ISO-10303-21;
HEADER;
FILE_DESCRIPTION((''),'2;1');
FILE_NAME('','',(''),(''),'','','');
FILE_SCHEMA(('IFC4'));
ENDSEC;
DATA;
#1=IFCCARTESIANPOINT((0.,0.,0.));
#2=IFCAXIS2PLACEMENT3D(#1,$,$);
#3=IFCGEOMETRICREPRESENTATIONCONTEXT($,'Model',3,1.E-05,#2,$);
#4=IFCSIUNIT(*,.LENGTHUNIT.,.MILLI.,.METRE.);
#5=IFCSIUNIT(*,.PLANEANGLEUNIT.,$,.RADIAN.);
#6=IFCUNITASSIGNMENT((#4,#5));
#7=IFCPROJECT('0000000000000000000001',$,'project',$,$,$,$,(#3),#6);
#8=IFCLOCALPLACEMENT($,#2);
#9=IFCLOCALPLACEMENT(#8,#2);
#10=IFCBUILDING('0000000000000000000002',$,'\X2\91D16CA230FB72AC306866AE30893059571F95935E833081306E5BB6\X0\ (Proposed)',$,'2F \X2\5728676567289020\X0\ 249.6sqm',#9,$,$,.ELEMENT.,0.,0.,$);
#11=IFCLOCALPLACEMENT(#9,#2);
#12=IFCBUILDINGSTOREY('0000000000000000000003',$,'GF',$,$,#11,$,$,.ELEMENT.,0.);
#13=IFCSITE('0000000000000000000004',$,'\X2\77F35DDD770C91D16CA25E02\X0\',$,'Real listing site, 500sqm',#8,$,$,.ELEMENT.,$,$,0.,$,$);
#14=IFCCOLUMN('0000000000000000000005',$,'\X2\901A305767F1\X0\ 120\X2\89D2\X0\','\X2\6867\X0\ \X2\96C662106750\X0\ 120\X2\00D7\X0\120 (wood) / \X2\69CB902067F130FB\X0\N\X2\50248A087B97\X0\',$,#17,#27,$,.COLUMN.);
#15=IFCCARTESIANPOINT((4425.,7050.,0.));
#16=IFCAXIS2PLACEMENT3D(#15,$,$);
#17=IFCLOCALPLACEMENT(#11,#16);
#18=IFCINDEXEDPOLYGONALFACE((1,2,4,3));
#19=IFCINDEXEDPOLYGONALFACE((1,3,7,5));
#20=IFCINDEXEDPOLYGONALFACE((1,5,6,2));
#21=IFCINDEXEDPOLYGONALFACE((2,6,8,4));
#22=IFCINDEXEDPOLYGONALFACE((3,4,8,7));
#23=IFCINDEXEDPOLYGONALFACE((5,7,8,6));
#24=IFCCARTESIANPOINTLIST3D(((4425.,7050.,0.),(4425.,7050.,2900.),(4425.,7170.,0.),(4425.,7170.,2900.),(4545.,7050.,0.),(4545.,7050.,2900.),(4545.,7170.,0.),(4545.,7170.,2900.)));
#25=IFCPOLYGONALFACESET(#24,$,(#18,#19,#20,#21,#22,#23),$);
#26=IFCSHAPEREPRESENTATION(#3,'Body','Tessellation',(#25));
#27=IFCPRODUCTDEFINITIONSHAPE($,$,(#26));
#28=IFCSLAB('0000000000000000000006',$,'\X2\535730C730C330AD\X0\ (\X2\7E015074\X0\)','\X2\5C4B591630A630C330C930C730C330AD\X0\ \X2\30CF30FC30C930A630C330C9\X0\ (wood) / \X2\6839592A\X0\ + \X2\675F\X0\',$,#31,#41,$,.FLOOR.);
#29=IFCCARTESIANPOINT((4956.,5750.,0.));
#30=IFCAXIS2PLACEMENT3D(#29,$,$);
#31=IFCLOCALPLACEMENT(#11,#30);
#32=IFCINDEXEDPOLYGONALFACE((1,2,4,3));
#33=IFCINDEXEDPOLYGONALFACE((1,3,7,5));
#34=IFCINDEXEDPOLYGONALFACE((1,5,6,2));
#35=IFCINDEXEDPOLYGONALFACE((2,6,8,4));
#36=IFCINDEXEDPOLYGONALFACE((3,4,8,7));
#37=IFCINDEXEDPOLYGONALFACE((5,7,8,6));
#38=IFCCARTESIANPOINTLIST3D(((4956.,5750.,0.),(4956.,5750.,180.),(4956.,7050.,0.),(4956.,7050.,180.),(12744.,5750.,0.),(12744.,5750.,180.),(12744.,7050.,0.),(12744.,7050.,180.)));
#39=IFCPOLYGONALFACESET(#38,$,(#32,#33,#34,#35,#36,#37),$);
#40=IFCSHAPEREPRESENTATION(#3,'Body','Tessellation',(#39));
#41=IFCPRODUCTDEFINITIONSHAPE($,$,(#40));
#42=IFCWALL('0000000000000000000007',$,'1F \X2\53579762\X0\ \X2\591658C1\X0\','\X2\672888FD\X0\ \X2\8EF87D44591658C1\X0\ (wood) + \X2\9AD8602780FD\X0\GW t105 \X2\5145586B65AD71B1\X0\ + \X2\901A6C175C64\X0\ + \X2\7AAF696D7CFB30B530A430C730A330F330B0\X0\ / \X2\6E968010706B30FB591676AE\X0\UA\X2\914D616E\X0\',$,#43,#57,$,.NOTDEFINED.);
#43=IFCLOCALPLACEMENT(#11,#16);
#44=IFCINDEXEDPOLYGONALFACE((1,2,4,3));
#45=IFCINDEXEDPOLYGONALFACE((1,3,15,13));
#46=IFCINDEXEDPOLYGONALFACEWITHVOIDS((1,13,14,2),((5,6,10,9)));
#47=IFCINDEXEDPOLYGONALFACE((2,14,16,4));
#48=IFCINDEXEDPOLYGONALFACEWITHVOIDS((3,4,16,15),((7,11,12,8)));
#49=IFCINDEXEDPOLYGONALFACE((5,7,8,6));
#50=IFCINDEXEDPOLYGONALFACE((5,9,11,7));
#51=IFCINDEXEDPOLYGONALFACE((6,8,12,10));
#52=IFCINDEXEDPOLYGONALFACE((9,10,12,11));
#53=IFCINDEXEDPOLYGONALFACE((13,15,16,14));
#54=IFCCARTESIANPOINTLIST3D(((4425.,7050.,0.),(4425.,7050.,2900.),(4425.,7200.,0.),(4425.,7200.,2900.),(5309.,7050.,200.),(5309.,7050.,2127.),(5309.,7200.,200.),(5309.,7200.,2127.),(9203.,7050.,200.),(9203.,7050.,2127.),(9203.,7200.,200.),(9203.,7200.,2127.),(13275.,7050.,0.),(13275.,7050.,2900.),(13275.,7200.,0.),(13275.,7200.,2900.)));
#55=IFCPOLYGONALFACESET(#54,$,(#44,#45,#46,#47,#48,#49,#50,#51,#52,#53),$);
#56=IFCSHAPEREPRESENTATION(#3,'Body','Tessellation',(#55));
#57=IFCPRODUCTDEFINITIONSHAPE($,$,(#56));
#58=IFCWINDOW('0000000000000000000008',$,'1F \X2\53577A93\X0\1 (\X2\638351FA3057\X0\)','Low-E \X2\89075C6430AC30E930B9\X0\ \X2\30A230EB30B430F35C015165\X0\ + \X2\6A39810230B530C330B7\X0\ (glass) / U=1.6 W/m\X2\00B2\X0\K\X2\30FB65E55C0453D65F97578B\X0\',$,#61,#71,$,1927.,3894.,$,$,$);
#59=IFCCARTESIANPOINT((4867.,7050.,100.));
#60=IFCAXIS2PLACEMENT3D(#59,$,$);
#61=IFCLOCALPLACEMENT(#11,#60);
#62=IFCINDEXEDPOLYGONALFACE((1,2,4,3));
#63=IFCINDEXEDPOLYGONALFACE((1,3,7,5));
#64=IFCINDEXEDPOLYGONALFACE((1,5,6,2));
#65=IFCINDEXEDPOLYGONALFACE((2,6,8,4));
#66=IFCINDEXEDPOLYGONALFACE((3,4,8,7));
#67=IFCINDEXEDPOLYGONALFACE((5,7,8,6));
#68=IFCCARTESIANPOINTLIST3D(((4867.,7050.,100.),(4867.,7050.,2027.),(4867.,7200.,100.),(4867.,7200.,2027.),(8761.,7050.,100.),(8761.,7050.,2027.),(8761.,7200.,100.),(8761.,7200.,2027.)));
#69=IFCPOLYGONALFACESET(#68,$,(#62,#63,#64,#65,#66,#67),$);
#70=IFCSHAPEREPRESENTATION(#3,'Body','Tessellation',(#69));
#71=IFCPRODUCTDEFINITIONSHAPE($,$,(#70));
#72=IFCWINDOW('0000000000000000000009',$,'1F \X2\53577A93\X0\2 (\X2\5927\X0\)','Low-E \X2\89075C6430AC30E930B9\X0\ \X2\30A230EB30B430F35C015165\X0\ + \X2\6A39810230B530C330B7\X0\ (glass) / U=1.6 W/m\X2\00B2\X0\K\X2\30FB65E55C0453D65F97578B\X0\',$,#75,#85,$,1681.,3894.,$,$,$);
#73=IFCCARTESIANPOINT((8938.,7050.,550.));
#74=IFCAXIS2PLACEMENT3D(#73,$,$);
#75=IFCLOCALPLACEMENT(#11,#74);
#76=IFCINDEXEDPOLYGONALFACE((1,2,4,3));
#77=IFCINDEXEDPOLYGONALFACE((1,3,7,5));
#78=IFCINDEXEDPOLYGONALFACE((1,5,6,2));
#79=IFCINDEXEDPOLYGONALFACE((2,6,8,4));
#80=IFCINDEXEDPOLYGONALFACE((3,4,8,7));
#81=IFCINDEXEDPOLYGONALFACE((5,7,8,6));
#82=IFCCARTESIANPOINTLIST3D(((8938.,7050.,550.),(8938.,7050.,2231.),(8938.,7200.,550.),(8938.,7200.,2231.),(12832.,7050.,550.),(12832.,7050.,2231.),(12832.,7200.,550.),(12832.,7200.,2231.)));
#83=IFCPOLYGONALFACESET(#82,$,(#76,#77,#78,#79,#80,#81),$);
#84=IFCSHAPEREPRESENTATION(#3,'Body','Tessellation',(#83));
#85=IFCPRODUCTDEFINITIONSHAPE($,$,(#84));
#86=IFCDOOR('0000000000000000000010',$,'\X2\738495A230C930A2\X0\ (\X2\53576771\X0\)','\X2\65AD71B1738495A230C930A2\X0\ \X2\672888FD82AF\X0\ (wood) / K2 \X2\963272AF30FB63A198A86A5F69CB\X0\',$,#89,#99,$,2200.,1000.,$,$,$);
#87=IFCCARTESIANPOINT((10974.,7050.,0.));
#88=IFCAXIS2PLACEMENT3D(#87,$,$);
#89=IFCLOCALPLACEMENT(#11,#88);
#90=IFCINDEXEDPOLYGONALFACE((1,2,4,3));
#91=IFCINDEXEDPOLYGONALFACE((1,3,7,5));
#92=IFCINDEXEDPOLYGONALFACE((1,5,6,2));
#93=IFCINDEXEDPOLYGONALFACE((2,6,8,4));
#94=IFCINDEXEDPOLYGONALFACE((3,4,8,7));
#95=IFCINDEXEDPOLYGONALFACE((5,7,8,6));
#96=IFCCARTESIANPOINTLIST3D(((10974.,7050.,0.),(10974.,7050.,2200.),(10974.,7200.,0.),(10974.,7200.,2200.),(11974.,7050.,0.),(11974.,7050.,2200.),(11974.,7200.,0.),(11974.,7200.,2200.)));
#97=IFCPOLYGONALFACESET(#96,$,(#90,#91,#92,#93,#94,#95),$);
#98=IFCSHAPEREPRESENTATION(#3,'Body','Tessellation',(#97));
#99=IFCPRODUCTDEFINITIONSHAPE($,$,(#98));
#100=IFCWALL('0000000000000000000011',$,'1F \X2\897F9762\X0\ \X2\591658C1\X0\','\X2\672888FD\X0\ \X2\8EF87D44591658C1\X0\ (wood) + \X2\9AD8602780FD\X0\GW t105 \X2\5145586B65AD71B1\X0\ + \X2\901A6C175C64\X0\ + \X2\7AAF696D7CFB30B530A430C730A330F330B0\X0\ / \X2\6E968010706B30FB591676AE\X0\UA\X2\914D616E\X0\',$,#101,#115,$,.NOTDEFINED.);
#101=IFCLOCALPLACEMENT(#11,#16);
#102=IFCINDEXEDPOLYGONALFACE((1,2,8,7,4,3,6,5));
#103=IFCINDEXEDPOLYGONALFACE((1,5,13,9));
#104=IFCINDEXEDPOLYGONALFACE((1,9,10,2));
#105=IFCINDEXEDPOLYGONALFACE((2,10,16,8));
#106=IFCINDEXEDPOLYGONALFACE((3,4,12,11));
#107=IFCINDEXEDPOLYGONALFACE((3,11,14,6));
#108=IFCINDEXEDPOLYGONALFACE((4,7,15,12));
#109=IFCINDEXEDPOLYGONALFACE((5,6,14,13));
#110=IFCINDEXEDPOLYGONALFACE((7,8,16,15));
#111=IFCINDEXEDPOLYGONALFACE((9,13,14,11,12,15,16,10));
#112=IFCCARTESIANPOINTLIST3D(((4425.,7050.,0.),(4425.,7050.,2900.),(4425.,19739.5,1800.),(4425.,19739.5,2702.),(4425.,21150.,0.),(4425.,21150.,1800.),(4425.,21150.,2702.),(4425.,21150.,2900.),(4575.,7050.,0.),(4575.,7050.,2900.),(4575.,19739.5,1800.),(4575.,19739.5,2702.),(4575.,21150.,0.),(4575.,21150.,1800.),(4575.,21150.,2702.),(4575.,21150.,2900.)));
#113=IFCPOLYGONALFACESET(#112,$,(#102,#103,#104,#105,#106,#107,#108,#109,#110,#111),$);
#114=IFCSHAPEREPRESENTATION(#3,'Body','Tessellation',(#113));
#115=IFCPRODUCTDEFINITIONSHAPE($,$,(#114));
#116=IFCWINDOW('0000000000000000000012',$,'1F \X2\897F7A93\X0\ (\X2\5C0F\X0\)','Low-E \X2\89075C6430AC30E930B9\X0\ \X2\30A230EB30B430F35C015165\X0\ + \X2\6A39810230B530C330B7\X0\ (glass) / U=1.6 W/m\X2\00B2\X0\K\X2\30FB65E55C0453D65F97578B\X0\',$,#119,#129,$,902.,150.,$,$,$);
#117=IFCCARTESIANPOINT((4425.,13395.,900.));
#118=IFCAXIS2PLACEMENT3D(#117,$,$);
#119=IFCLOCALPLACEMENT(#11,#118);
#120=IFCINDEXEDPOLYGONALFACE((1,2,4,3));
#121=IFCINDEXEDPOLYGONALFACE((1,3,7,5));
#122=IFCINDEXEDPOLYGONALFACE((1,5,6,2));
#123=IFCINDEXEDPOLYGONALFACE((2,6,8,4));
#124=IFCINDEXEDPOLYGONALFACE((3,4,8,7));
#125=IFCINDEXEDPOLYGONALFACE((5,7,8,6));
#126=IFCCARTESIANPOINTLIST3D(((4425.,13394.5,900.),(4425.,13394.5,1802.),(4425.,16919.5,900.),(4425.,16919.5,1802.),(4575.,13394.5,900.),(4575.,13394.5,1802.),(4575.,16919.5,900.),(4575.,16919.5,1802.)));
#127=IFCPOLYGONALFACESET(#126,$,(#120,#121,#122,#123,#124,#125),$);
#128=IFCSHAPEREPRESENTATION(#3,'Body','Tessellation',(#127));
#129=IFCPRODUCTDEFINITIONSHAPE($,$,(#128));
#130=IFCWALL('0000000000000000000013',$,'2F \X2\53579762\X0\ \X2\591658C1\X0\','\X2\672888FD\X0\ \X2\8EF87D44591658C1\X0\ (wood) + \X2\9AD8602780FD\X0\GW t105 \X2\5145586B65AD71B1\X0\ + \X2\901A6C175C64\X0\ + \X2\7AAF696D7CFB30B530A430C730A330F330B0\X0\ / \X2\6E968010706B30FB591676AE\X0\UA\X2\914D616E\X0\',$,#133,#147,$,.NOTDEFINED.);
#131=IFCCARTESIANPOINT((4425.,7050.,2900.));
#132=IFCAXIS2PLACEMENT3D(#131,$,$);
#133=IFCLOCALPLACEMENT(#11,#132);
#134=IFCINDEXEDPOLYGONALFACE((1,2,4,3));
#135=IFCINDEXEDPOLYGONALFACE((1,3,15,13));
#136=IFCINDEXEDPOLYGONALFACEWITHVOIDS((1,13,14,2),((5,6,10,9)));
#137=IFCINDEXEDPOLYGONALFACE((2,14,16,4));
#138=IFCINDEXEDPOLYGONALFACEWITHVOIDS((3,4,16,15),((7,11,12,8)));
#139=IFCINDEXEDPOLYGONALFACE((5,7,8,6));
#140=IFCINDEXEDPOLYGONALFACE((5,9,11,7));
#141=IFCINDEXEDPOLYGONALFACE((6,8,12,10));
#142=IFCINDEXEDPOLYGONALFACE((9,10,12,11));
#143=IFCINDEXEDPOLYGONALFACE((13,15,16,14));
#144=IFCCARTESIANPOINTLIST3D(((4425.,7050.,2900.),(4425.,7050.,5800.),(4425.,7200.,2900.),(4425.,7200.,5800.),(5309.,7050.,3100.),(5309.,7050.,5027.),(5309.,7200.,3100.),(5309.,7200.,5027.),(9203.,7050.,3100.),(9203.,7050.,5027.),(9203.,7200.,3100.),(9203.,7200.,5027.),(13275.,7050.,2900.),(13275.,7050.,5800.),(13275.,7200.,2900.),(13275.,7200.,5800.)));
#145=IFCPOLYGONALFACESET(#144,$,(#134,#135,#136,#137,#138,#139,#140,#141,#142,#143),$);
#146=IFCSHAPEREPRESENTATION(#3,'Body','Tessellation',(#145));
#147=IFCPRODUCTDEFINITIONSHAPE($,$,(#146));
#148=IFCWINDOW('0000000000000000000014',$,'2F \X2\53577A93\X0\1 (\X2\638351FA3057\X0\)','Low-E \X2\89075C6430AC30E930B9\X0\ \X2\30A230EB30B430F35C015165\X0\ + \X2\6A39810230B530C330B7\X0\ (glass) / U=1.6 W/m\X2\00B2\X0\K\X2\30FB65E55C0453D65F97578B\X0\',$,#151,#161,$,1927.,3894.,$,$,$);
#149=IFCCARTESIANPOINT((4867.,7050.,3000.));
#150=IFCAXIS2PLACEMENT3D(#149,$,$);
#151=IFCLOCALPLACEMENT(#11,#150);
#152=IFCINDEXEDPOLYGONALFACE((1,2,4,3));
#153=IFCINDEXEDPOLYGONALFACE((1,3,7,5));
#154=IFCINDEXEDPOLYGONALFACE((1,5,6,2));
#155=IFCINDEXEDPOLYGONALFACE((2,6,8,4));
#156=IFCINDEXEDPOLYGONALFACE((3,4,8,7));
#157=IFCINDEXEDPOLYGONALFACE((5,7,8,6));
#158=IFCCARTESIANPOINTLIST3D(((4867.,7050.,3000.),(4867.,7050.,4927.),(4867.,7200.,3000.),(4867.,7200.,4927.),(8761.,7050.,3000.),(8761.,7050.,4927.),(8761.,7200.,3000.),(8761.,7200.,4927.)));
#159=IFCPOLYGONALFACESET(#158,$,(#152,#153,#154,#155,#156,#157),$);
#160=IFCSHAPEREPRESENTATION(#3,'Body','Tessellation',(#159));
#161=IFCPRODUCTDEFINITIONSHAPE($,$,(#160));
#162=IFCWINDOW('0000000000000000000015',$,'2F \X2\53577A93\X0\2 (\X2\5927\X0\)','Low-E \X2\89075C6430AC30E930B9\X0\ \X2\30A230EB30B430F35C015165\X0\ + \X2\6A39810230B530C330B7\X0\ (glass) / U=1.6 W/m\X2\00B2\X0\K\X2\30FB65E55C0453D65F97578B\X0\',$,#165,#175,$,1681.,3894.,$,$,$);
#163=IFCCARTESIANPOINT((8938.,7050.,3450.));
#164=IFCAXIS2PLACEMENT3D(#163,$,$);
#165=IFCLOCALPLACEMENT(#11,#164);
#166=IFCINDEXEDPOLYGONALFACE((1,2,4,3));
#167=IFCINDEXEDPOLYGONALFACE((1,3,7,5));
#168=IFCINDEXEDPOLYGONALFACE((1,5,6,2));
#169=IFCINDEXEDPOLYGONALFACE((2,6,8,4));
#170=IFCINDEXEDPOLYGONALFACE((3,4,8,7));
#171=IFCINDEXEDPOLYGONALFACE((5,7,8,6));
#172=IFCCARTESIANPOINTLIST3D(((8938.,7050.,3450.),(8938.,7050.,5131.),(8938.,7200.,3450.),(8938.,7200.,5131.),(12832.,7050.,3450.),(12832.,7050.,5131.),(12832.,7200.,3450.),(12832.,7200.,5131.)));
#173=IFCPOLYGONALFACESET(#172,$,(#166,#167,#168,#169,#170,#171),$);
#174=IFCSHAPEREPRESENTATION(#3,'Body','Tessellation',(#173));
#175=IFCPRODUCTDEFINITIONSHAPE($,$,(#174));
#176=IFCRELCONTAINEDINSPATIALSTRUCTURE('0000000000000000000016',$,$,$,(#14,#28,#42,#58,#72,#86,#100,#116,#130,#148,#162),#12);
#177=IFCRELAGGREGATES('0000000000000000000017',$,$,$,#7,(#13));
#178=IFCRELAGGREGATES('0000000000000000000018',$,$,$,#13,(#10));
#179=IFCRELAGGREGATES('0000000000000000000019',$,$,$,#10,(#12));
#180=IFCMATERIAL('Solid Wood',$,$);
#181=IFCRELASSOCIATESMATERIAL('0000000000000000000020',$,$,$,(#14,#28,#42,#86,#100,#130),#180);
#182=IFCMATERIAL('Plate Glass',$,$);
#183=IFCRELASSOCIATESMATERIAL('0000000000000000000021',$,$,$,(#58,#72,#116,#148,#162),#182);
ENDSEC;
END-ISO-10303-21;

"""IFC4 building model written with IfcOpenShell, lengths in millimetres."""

from ifc_helpers import new_model, si_unit, frame, frame_2d, origin, place, context, project, spatial, rectangle, extrude, material, element, fill, save


model = new_model("IFC4")

# Units and contexts
model_context = context("Model", 3, precision=1e-05, world=origin())
ifc_project = project(units=[si_unit("LENGTHUNIT", "METRE", prefix="MILLI"), si_unit("PLANEANGLEUNIT", "RADIAN")], contexts=[model_context])

# Site, building, storey
site_placement = place(None, origin())
site = spatial("IfcSite", under=ifc_project, at=site_placement, Name="石川県金沢市", ObjectType="Real listing site, 500sqm", CompositionType="ELEMENT", RefElevation=0.0)
building_placement = place(site_placement, origin())
building = spatial("IfcBuilding", under=site, at=building_placement, Name="金沢・犬と暮らす土間広めの家 (Proposed)", ObjectType="2F 在来木造 249.6sqm", CompositionType="ELEMENT", ElevationOfRefHeight=0.0, ElevationOfTerrain=0.0)
storey_placement = place(building_placement, origin())
storey = spatial("IfcBuildingStorey", under=building, at=storey_placement, Name="GF", CompositionType="ELEMENT", Elevation=0.0)

# Column
ifc_material_1 = material(Name="Solid Wood")
column_placement = place(storey_placement, frame((4425.0, 7050.0, 0.0)))
element("IfcColumn", 1, at=column_placement, inside=storey, material=ifc_material_1, Name="通し柱 120角", Description="桧 集成材 120×120 (wood) / 構造柱・N値計算", PredefinedType="COLUMN", context=model_context, shape_type="SweptSolid", body=[
    extrude(rectangle(XDim=120.0, YDim=120.0, at=frame_2d((60.0, 60.0))), frame((4425.0, 7050.0, 0.0)), (0.0, 0.0, 1.0), 2900.0),
])

# Slab
slab_1_placement = place(storey_placement, frame((4956.0, 5750.0, 0.0)))
element("IfcSlab", 2, at=slab_1_placement, inside=storey, material=ifc_material_1, Name="南デッキ (縁側)", Description="屋外ウッドデッキ ハードウッド (wood) / 根太 + 束", PredefinedType="FLOOR", context=model_context, shape_type="SweptSolid", body=[
    extrude(rectangle(XDim=7788.0, YDim=1300.0, at=frame_2d((3894.0, 650.0))), frame((4956.0, 5750.0, 0.0)), (0.0, 0.0, 1.0), 180.0),
])

# Wall, openings, windows, door
wall_1_placement = place(storey_placement, frame((4425.0, 7050.0, 0.0)))
wall_1 = element("IfcWall", 3, at=wall_1_placement, inside=storey, material=ifc_material_1, Name="1F 南面 外壁", Description="木製 軸組外壁 (wood) + 高性能GW t105 充填断熱 + 通気層 + 窯業系サイディング / 準耐火・外皮UA配慮", PredefinedType="NOTDEFINED", context=model_context, shape_type="SweptSolid", body=[
    extrude(rectangle(XDim=8850.0, YDim=150.0, at=frame_2d((4425.0, 75.0))), frame((4425.0, 7050.0, 0.0)), (0.0, 0.0, 1.0), 2900.0),
])
opening_1_placement = place(storey_placement, frame((4867.0, 7050.0, 100.0)))
opening_1 = element("IfcOpeningElement", 4, at=opening_1_placement, cuts=wall_1, PredefinedType="NOTDEFINED", context=model_context, shape_type="SweptSolid", body=[
    extrude(rectangle(XDim=3894.0, YDim=150.0, at=frame_2d((1947.0, 75.0))), frame((4867.0, 7050.0, 100.0)), (0.0, 0.0, 1.0), 1927.0),
])
opening_2_placement = place(storey_placement, frame((8938.0, 7050.0, 550.0)))
opening_2 = element("IfcOpeningElement", 5, at=opening_2_placement, cuts=wall_1, PredefinedType="NOTDEFINED", context=model_context, shape_type="SweptSolid", body=[
    extrude(rectangle(XDim=3894.0, YDim=150.0, at=frame_2d((1947.0, 75.0))), frame((8938.0, 7050.0, 550.0)), (0.0, 0.0, 1.0), 1681.0),
])
opening_3_placement = place(storey_placement, frame((10974.0, 7050.0, 0.0)))
opening_3 = element("IfcOpeningElement", 6, at=opening_3_placement, cuts=wall_1, PredefinedType="NOTDEFINED", context=model_context, shape_type="SweptSolid", body=[
    extrude(rectangle(XDim=1000.0, YDim=150.0, at=frame_2d((500.0, 75.0))), frame((10974.0, 7050.0, 0.0)), (0.0, 0.0, 1.0), 2200.0),
])
ifc_material_2 = material(Name="Plate Glass")
window_1_placement = place(storey_placement, frame((4867.0, 7050.0, 100.0)))
window_1 = element("IfcWindow", 7, at=window_1_placement, inside=storey, material=ifc_material_2, Name="1F 南窓1 (掃出し)", Description="Low-E 複層ガラス アルゴン封入 + 樹脂サッシ (glass) / U=1.6 W/m²K・日射取得型", OverallHeight=1927.0, OverallWidth=3894.0, context=model_context, shape_type="SweptSolid", body=[
    extrude(rectangle(XDim=3894.0, YDim=150.0, at=frame_2d((1947.0, 75.0))), frame((4867.0, 7050.0, 100.0)), (0.0, 0.0, 1.0), 1927.0),
])
fill(opening_1, window_1)
window_2_placement = place(storey_placement, frame((8938.0, 7050.0, 550.0)))
window_2 = element("IfcWindow", 8, at=window_2_placement, inside=storey, material=ifc_material_2, Name="1F 南窓2 (大)", Description="Low-E 複層ガラス アルゴン封入 + 樹脂サッシ (glass) / U=1.6 W/m²K・日射取得型", OverallHeight=1681.0, OverallWidth=3894.0, context=model_context, shape_type="SweptSolid", body=[
    extrude(rectangle(XDim=3894.0, YDim=150.0, at=frame_2d((1947.0, 75.0))), frame((8938.0, 7050.0, 550.0)), (0.0, 0.0, 1.0), 1681.0),
])
fill(opening_2, window_2)
door_placement = place(storey_placement, frame((10974.0, 7050.0, 0.0)))
door = element("IfcDoor", 9, at=door_placement, inside=storey, material=ifc_material_1, Name="玄関ドア (南東)", Description="断熱玄関ドア 木製芯 (wood) / K2 防犯・採風機構", OverallHeight=2200.0, OverallWidth=1000.0, context=model_context, shape_type="SweptSolid", body=[
    extrude(rectangle(XDim=1000.0, YDim=150.0, at=frame_2d((500.0, 75.0))), frame((10974.0, 7050.0, 0.0)), (0.0, 0.0, 1.0), 2200.0),
])
fill(opening_3, door)

# Wall, opening, window
wall_2_placement = place(storey_placement, frame((4425.0, 7050.0, 0.0)))
wall_2 = element("IfcWall", 10, at=wall_2_placement, inside=storey, material=ifc_material_1, Name="1F 西面 外壁", Description="木製 軸組外壁 (wood) + 高性能GW t105 充填断熱 + 通気層 + 窯業系サイディング / 準耐火・外皮UA配慮", PredefinedType="NOTDEFINED", context=model_context, shape_type="SweptSolid", body=[
    extrude(rectangle(XDim=150.0, YDim=14100.0, at=frame_2d((75.0, 7050.0))), frame((4425.0, 7050.0, 0.0)), (0.0, 0.0, 1.0), 2900.0),
])
opening_4_placement = place(storey_placement, frame((4425.0, 13395.0, 900.0)))
opening_4 = element("IfcOpeningElement", 11, at=opening_4_placement, cuts=wall_2, PredefinedType="NOTDEFINED", context=model_context, shape_type="SweptSolid", body=[
    extrude(rectangle(XDim=150.0, YDim=3525.0, at=frame_2d((75.0, 1762.0))), frame((4425.0, 13395.0, 900.0)), (0.0, 0.0, 1.0), 902.0),
])
window_3_placement = place(storey_placement, frame((4425.0, 13395.0, 900.0)))
window_3 = element("IfcWindow", 12, at=window_3_placement, inside=storey, material=ifc_material_2, Name="1F 西窓 (小)", Description="Low-E 複層ガラス アルゴン封入 + 樹脂サッシ (glass) / U=1.6 W/m²K・日射取得型", OverallHeight=902.0, OverallWidth=150.0, context=model_context, shape_type="SweptSolid", body=[
    extrude(rectangle(XDim=150.0, YDim=3525.0, at=frame_2d((75.0, 1762.0))), frame((4425.0, 13395.0, 900.0)), (0.0, 0.0, 1.0), 902.0),
])
fill(opening_4, window_3)

# Wall, openings, windows
wall_3_placement = place(storey_placement, frame((4425.0, 7050.0, 2900.0)))
wall_3 = element("IfcWall", 13, at=wall_3_placement, inside=storey, material=ifc_material_1, Name="2F 南面 外壁", Description="木製 軸組外壁 (wood) + 高性能GW t105 充填断熱 + 通気層 + 窯業系サイディング / 準耐火・外皮UA配慮", PredefinedType="NOTDEFINED", context=model_context, shape_type="SweptSolid", body=[
    extrude(rectangle(XDim=8850.0, YDim=150.0, at=frame_2d((4425.0, 75.0))), frame((4425.0, 7050.0, 2900.0)), (0.0, 0.0, 1.0), 2900.0),
])
opening_5_placement = place(storey_placement, frame((4867.0, 7050.0, 3000.0)))
opening_5 = element("IfcOpeningElement", 14, at=opening_5_placement, cuts=wall_3, PredefinedType="NOTDEFINED", context=model_context, shape_type="SweptSolid", body=[
    extrude(rectangle(XDim=3894.0, YDim=150.0, at=frame_2d((1947.0, 75.0))), frame((4867.0, 7050.0, 3000.0)), (0.0, 0.0, 1.0), 1927.0),
])
opening_6_placement = place(storey_placement, frame((8938.0, 7050.0, 3450.0)))
opening_6 = element("IfcOpeningElement", 15, at=opening_6_placement, cuts=wall_3, PredefinedType="NOTDEFINED", context=model_context, shape_type="SweptSolid", body=[
    extrude(rectangle(XDim=3894.0, YDim=150.0, at=frame_2d((1947.0, 75.0))), frame((8938.0, 7050.0, 3450.0)), (0.0, 0.0, 1.0), 1681.0),
])
window_4_placement = place(storey_placement, frame((4867.0, 7050.0, 3000.0)))
window_4 = element("IfcWindow", 16, at=window_4_placement, inside=storey, material=ifc_material_2, Name="2F 南窓1 (掃出し)", Description="Low-E 複層ガラス アルゴン封入 + 樹脂サッシ (glass) / U=1.6 W/m²K・日射取得型", OverallHeight=1927.0, OverallWidth=3894.0, context=model_context, shape_type="SweptSolid", body=[
    extrude(rectangle(XDim=3894.0, YDim=150.0, at=frame_2d((1947.0, 75.0))), frame((4867.0, 7050.0, 3000.0)), (0.0, 0.0, 1.0), 1927.0),
])
fill(opening_5, window_4)
window_5_placement = place(storey_placement, frame((8938.0, 7050.0, 3450.0)))
window_5 = element("IfcWindow", 17, at=window_5_placement, inside=storey, material=ifc_material_2, Name="2F 南窓2 (大)", Description="Low-E 複層ガラス アルゴン封入 + 樹脂サッシ (glass) / U=1.6 W/m²K・日射取得型", OverallHeight=1681.0, OverallWidth=3894.0, context=model_context, shape_type="SweptSolid", body=[
    extrude(rectangle(XDim=3894.0, YDim=150.0, at=frame_2d((1947.0, 75.0))), frame((8938.0, 7050.0, 3450.0)), (0.0, 0.0, 1.0), 1681.0),
])
fill(opening_6, window_5)

save(model, "model.ifc")
